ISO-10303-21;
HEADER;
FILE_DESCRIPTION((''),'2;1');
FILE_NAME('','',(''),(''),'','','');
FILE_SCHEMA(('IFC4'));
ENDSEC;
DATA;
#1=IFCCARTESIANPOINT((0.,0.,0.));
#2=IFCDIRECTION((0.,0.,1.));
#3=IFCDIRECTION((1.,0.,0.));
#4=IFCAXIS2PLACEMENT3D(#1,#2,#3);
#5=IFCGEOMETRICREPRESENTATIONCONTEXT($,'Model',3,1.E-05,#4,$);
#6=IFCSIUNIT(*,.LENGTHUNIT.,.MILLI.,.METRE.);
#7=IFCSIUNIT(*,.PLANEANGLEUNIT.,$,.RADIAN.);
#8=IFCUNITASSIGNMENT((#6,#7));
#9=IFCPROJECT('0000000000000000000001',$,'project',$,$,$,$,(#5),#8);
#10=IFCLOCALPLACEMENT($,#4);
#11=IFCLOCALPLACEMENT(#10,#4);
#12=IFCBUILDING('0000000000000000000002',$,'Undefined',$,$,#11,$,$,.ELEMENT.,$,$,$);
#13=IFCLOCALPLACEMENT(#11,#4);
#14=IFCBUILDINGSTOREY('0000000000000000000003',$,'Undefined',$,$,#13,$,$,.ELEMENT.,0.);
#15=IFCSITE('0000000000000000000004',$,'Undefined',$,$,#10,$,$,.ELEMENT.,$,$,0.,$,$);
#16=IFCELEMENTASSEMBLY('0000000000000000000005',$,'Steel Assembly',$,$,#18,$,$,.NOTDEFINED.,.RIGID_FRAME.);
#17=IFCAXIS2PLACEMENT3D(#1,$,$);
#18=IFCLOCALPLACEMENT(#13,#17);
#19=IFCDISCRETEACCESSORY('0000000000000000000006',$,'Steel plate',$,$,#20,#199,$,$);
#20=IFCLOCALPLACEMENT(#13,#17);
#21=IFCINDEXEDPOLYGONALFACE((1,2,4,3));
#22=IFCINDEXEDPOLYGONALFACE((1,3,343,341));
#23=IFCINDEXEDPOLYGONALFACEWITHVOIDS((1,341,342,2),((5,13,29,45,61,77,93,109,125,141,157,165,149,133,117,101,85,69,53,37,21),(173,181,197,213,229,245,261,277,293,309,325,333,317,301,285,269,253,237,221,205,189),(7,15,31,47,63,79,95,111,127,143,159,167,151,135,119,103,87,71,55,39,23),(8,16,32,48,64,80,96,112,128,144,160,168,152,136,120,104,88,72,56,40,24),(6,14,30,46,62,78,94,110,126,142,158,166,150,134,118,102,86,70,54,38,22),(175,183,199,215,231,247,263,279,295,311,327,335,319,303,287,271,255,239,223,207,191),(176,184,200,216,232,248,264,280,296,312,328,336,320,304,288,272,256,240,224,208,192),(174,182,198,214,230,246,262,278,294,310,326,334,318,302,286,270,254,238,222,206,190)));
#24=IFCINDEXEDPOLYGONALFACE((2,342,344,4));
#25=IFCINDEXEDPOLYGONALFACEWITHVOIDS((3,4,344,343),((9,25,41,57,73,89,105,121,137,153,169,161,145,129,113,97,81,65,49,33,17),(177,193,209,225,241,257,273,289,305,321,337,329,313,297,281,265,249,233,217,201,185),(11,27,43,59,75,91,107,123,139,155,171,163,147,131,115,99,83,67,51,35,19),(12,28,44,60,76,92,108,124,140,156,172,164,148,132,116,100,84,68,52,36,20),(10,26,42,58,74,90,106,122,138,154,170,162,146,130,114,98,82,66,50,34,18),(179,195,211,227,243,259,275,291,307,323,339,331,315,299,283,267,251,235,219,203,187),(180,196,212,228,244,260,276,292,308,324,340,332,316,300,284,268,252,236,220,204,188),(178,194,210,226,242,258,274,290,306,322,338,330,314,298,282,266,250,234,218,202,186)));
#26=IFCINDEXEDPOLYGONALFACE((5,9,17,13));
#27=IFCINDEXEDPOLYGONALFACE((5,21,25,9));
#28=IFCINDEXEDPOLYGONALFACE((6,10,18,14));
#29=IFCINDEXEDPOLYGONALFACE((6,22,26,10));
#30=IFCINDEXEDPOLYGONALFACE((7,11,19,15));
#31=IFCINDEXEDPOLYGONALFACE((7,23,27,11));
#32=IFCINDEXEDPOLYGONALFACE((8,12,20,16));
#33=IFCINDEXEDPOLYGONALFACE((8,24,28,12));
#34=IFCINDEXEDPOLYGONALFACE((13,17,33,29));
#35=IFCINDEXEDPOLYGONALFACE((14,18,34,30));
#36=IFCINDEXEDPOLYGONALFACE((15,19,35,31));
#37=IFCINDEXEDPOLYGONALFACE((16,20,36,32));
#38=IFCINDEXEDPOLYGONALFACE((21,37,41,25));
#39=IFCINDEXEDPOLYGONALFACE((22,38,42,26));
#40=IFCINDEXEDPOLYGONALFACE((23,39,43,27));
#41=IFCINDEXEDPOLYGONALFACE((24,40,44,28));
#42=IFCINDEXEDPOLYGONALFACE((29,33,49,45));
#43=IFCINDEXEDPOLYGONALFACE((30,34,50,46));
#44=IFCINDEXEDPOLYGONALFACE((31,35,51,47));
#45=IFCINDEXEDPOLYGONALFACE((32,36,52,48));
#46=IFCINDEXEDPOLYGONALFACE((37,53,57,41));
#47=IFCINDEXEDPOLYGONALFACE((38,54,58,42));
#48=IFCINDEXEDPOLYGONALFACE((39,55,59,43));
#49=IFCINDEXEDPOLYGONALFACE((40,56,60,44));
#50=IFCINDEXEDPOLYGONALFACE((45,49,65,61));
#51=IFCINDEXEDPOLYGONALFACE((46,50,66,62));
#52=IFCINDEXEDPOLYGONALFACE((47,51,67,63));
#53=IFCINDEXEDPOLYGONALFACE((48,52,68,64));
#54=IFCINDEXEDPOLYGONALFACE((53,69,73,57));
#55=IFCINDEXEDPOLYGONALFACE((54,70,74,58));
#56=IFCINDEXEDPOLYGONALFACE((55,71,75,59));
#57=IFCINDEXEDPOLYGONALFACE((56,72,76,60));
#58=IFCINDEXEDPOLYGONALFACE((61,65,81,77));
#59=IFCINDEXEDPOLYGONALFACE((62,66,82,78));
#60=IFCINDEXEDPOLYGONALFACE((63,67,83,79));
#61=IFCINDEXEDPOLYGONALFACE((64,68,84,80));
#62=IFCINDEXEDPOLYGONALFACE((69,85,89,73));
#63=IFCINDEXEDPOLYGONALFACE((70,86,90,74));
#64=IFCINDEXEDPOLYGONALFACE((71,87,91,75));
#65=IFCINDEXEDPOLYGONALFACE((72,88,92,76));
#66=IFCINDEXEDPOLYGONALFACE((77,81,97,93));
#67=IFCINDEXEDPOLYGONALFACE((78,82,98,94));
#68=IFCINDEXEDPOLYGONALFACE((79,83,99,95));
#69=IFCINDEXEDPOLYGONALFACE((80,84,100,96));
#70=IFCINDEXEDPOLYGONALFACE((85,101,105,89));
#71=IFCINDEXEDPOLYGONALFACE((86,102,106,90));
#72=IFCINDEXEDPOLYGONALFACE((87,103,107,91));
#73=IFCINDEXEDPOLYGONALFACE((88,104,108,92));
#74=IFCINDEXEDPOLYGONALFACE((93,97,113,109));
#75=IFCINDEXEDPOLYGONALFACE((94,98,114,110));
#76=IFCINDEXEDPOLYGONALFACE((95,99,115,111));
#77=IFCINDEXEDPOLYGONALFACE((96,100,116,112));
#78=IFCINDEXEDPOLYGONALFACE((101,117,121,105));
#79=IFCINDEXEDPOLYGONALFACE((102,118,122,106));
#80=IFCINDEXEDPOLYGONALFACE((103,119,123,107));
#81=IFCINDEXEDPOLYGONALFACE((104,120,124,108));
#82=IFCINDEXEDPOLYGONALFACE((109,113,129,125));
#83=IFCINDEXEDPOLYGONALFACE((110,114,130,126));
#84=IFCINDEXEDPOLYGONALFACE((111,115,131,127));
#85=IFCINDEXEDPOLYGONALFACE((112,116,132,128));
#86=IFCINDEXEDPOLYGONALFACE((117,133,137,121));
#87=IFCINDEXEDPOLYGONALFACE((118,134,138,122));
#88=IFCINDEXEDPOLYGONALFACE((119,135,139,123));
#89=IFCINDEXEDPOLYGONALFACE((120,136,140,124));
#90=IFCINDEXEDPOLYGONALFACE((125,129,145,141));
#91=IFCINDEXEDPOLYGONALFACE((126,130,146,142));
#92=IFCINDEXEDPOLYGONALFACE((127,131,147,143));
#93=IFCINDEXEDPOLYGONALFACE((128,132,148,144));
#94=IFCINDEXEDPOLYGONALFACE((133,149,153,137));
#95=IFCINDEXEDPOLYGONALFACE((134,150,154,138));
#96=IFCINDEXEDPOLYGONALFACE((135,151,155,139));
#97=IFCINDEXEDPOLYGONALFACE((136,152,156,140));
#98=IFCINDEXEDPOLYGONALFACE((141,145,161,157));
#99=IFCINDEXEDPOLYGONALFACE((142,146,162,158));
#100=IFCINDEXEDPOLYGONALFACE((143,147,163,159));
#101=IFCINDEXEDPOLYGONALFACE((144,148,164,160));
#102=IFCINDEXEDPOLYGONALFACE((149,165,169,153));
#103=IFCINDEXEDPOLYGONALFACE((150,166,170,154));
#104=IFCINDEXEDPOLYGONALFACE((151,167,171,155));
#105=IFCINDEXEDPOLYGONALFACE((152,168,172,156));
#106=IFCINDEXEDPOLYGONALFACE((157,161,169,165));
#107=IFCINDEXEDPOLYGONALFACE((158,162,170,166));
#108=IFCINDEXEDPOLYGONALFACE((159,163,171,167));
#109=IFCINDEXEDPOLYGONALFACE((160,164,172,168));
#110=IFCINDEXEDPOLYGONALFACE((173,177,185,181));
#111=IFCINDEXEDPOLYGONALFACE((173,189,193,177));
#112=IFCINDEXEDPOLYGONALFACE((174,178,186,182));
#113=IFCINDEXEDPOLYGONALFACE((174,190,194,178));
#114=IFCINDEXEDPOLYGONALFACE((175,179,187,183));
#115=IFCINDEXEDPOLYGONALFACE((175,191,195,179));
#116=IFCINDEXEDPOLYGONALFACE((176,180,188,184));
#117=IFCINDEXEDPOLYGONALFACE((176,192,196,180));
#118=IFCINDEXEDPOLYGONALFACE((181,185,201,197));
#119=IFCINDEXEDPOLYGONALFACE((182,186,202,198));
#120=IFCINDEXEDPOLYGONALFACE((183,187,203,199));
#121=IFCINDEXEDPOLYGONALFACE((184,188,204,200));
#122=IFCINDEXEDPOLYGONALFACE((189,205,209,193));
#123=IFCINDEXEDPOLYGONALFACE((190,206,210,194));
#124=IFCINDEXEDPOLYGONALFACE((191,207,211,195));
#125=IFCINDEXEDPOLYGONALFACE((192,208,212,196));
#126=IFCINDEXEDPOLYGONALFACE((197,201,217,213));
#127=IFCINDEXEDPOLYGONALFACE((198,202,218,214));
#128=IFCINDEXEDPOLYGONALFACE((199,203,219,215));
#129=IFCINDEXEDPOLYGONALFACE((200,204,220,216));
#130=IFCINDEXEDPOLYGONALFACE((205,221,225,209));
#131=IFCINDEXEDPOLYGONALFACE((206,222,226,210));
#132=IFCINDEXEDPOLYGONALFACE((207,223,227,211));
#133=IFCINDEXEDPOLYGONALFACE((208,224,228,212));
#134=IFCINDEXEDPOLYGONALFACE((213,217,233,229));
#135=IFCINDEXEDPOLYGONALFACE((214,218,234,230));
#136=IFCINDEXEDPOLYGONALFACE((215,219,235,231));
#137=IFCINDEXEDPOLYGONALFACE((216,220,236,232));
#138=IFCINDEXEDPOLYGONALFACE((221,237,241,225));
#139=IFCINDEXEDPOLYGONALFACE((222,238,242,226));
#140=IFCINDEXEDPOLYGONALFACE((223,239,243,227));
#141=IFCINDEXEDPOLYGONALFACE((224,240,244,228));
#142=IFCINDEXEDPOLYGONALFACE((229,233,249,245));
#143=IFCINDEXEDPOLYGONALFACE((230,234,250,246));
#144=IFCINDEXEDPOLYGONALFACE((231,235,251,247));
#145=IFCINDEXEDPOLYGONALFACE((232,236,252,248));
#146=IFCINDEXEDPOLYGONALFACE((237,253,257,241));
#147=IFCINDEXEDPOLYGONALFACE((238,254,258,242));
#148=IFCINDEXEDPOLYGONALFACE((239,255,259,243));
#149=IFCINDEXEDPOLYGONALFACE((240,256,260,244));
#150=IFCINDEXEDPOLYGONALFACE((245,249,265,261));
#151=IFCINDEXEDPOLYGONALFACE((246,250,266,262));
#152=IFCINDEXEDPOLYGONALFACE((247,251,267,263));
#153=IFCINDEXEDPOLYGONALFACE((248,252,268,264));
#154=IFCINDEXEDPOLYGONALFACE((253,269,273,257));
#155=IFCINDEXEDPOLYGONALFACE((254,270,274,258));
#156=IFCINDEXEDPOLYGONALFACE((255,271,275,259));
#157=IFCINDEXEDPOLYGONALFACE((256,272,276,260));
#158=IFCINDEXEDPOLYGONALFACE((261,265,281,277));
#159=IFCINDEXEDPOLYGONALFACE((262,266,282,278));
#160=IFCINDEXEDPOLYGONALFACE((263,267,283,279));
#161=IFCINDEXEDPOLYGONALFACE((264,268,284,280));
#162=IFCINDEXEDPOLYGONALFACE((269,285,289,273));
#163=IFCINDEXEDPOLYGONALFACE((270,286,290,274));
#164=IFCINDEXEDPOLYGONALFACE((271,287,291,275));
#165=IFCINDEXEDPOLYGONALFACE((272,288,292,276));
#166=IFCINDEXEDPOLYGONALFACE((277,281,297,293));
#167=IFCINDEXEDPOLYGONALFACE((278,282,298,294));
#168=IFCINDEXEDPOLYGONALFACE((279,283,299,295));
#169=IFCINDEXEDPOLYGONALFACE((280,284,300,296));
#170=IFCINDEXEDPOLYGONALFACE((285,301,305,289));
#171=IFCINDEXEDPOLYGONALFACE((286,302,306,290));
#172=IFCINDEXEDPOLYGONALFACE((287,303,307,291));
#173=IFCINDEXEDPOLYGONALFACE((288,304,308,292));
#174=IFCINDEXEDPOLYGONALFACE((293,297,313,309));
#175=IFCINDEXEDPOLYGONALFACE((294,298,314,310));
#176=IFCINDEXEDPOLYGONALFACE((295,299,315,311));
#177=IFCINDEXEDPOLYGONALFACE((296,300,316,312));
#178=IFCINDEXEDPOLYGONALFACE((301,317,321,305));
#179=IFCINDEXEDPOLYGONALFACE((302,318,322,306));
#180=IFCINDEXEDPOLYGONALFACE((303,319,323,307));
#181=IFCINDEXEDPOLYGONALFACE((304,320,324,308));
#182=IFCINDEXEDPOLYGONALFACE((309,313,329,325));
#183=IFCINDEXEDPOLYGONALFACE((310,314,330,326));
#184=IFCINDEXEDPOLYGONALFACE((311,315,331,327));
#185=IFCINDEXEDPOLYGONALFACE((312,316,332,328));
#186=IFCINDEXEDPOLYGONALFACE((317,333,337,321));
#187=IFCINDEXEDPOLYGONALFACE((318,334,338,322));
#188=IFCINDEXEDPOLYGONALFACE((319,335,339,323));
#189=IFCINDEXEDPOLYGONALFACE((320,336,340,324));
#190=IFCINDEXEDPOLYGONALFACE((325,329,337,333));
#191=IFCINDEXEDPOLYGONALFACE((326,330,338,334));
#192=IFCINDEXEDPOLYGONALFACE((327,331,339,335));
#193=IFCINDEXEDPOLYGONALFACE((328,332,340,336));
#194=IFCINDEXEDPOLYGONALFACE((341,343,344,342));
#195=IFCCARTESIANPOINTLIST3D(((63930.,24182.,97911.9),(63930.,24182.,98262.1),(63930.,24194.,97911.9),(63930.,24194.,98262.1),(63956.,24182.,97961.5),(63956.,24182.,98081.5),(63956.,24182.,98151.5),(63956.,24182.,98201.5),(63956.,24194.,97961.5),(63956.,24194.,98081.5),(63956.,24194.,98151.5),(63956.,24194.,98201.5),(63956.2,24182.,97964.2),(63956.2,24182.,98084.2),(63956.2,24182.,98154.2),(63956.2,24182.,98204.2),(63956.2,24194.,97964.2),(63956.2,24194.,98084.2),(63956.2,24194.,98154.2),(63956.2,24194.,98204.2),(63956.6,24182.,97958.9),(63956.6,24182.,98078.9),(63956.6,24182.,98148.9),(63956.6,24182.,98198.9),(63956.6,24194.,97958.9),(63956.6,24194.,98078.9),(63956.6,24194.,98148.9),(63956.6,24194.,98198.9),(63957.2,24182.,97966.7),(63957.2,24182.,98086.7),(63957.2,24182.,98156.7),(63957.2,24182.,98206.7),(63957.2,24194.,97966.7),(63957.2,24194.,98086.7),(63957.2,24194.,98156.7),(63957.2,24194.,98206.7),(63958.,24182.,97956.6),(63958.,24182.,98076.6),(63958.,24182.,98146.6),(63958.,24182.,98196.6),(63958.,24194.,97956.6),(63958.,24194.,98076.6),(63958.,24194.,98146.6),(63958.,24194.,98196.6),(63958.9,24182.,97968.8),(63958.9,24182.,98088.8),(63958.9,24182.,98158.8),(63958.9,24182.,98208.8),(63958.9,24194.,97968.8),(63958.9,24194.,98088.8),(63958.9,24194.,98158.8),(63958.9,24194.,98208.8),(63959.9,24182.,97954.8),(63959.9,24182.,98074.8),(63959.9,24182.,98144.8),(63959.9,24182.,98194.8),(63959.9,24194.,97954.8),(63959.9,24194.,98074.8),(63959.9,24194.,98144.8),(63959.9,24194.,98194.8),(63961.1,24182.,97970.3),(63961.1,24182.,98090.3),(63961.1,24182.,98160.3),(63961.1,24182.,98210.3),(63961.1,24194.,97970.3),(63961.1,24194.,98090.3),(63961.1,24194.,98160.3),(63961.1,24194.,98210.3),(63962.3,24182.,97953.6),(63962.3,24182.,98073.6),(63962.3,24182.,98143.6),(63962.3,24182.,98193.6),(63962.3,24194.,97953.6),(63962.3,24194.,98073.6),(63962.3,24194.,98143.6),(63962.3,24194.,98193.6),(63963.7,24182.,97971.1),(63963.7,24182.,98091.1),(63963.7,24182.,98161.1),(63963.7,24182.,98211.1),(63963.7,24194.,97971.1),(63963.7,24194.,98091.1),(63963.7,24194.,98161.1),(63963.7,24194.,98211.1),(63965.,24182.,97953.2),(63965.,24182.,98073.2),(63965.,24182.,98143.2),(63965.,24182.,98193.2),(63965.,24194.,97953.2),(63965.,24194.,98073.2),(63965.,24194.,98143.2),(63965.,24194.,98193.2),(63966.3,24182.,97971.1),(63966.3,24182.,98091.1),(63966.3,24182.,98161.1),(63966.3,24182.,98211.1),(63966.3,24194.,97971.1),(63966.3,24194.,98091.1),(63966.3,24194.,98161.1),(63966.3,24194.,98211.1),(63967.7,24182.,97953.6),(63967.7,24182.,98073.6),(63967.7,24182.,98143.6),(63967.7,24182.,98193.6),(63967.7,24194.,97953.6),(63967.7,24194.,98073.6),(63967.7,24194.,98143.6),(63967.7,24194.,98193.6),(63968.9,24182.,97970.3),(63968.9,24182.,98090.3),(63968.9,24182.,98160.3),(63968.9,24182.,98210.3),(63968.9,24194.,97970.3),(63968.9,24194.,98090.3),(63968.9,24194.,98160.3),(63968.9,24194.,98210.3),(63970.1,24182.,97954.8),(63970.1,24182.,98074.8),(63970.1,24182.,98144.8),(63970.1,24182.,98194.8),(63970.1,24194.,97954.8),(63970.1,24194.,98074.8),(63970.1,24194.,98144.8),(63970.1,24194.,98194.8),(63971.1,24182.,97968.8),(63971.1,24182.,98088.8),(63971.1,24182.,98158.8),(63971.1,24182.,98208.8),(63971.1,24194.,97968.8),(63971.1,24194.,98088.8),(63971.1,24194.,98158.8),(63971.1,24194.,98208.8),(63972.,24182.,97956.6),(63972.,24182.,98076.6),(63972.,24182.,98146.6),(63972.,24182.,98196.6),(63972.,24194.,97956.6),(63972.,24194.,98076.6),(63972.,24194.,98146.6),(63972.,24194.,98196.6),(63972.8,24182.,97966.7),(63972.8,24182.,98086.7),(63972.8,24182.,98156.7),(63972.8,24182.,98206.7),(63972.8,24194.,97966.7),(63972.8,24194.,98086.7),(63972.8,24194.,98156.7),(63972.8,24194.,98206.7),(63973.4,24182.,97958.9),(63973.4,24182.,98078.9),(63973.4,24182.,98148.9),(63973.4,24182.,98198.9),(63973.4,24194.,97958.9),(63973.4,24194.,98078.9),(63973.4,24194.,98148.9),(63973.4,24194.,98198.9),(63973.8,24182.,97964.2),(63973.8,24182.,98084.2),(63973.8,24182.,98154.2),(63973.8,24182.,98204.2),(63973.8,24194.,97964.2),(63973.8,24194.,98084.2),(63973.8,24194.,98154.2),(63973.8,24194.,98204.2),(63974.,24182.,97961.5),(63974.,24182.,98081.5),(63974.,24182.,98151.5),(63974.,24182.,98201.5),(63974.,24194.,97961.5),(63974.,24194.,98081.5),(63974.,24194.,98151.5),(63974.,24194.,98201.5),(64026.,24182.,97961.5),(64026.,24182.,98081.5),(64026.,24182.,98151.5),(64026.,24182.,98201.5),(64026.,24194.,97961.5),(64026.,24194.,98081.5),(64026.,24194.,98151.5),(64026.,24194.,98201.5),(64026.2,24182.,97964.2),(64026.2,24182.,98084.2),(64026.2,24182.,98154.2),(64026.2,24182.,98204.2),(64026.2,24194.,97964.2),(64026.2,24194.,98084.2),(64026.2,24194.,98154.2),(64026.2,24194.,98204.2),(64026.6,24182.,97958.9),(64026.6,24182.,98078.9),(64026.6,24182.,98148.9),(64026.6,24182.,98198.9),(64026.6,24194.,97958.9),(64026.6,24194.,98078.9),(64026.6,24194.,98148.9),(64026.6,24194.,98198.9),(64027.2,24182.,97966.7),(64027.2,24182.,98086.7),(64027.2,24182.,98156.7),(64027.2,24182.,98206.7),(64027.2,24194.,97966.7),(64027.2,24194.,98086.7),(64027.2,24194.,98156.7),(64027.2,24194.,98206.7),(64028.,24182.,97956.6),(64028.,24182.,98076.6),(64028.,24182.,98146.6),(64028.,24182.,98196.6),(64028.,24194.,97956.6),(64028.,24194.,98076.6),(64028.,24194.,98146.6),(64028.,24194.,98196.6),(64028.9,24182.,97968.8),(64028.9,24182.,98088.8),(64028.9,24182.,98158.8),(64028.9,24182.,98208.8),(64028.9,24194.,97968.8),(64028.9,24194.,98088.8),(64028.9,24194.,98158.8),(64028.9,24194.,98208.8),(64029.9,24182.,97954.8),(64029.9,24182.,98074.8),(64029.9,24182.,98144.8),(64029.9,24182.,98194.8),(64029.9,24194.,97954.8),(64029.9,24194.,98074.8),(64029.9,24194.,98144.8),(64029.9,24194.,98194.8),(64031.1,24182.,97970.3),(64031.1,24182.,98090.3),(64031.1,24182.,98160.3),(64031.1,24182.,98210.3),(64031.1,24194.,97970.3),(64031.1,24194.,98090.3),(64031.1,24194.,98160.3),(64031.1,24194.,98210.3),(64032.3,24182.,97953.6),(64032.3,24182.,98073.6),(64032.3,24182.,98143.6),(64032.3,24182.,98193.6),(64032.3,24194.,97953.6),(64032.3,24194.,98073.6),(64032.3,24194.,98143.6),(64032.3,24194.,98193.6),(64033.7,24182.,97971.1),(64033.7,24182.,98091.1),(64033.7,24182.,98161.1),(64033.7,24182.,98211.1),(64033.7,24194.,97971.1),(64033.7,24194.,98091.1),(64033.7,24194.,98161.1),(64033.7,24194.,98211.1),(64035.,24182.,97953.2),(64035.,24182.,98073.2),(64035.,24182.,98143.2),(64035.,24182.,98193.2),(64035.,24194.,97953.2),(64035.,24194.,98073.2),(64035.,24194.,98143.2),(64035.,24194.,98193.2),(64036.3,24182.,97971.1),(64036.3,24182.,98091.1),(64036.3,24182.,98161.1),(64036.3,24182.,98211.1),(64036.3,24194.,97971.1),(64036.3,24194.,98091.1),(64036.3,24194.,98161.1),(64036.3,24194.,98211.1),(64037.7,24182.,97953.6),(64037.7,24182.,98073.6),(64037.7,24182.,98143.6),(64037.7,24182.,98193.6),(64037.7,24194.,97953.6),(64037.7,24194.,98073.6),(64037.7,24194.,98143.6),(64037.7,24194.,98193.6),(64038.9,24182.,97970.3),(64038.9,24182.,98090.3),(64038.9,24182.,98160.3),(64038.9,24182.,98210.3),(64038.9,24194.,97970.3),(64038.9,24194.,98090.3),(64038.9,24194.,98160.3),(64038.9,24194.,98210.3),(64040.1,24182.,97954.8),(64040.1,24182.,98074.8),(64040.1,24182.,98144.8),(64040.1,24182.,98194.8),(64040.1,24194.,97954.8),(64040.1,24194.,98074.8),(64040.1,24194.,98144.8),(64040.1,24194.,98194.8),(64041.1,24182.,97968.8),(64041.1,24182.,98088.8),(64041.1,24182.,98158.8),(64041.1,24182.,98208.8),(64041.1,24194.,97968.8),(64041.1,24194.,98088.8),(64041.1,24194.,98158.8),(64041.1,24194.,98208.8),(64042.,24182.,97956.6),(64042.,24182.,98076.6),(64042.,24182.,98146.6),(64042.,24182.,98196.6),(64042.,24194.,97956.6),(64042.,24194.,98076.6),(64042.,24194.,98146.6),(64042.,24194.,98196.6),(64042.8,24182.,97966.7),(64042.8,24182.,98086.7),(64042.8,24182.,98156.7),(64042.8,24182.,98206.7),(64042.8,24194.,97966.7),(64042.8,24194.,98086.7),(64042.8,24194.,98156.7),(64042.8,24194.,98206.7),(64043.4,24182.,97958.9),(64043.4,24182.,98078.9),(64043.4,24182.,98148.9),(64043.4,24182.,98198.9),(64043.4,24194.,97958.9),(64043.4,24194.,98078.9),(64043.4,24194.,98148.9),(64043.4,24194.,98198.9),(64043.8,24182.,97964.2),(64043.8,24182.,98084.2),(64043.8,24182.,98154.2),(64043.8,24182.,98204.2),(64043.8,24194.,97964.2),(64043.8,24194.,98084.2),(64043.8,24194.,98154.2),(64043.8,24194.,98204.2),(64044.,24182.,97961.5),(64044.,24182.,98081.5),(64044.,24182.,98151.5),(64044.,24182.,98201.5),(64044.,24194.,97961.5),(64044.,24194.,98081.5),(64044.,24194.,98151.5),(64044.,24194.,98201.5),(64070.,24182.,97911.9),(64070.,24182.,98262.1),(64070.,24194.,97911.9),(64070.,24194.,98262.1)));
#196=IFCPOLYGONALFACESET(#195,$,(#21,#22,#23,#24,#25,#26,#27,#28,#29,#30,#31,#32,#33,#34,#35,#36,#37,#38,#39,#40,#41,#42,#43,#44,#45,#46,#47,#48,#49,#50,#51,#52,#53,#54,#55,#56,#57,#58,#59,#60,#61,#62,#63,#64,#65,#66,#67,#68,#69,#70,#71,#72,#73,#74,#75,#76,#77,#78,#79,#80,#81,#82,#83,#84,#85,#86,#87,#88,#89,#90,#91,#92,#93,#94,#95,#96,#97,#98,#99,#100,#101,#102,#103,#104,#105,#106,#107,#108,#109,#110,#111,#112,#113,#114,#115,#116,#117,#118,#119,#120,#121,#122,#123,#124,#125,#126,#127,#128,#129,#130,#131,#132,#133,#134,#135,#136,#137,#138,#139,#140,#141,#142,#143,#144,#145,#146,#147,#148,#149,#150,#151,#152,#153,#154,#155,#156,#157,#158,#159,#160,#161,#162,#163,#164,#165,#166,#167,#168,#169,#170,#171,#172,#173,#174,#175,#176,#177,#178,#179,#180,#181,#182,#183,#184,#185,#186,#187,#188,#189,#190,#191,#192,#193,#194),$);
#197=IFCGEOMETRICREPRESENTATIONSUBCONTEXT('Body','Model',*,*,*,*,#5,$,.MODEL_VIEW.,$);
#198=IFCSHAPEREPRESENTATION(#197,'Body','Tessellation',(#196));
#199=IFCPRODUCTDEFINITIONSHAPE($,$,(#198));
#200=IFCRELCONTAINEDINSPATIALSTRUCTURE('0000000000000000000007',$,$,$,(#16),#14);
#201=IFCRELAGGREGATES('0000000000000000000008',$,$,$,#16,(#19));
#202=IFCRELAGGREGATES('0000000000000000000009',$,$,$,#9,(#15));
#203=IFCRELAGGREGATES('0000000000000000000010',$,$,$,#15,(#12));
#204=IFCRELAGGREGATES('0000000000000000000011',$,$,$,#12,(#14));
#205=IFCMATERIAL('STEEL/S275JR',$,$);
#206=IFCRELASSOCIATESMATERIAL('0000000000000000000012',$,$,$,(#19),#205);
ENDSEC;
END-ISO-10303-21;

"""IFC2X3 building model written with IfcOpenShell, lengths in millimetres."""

from ifc_helpers import new_model, si_unit, frame, origin_with_axes, origin_2d_with_axis, place, context, subcontext, project, spatial, polyline, circle, outline, extrude, source, transform, mapped, material, element, aggregate, save


model = new_model("IFC2X3")

# Units and contexts
model_context = context("Model", 3, precision=1e-05, world=origin_with_axes())
body_context = subcontext(model_context, "Body", "Model", "MODEL_VIEW")
ifc_project = project(units=[si_unit("LENGTHUNIT", "METRE", prefix="MILLI"), si_unit("PLANEANGLEUNIT", "RADIAN")], contexts=[model_context])

# Site, building, storey
site_placement = place(None, origin_with_axes())
site = spatial("IfcSite", under=ifc_project, at=site_placement, Name="Undefined", CompositionType="ELEMENT", RefElevation=0.0)
building_placement = place(site_placement, origin_with_axes())
building = spatial("IfcBuilding", under=site, at=building_placement, Name="Undefined", CompositionType="ELEMENT")
storey_placement = place(building_placement, origin_with_axes())
storey = spatial("IfcBuildingStorey", under=building, at=storey_placement, Name="Undefined", CompositionType="ELEMENT", Elevation=0.0)

# Shared definitions
ifc_material_1 = material(Name="STEEL/S275JR")

# Element assembly, discrete accessory, opening
assembly_1_placement = place(storey_placement, origin_with_axes())
assembly_1 = element("IfcElementAssembly", 1, at=assembly_1_placement, inside=storey, Name="Steel Assembly", AssemblyPlace="NOTDEFINED", PredefinedType="RIGID_FRAME")
discrete_accessory_1_placement = place(assembly_1_placement, frame((63930.0, 24188.0, 97911.9), z_axis=(0.0, -1.0, 0.0), x_axis=(1.0, 0.0, 0.0)))
discrete_accessory_1 = element("IfcDiscreteAccessory", 2, at=discrete_accessory_1_placement, material=ifc_material_1, Name="Steel plate", context=body_context, shape_type="SweptSolid", body=[
    extrude(outline(polyline([(0.0, 0.0), (140.0, 0.0), (140.0, 350.2), (0.0, 350.2), (0.0, 0.0)])), frame((0.0, 0.0, -6.0), z_axis=(0.0, 0.0, 1.0), x_axis=(1.0, 0.0, 0.0)), (0.0, 0.0, 1.0), 12.0),
])
shared_shape_1 = source(origin_with_axes(), body_context, "Body", "SweptSolid", [
    extrude(circle(Radius=9.0, at=origin_2d_with_axis()), frame((0.0, -0.1, 0.0), z_axis=(0.0, 1.0, 0.0), x_axis=(1.0, 0.0, 0.0)), (0.0, 0.0, 1.0), 12.2),
])
opening_1_placement = place(assembly_1_placement, frame((64000.0, 24182.0, 98202.2), z_axis=(1.0, 0.0, 0.0), x_axis=(0.0, 0.0, -1.0)))
element("IfcOpeningElement", 3, at=opening_1_placement, cuts=discrete_accessory_1, ObjectType="Opening", context=body_context, shape_type="MappedRepresentation", body=[
    mapped(shared_shape_1, transform((0.0, 0.0, -35.0))),
    mapped(shared_shape_1, transform((50.0, 0.0, -35.0))),
    mapped(shared_shape_1, transform((120.0, 0.0, -35.0))),
    mapped(shared_shape_1, transform((240.0, 0.0, -35.0))),
    mapped(shared_shape_1, transform((0.0, 0.0, 35.0))),
    mapped(shared_shape_1, transform((50.0, 0.0, 35.0))),
    mapped(shared_shape_1, transform((120.0, 0.0, 35.0))),
    mapped(shared_shape_1, transform((240.0, 0.0, 35.0))),
])
aggregate(assembly_1, [discrete_accessory_1])

save(model, "model.ifc")
